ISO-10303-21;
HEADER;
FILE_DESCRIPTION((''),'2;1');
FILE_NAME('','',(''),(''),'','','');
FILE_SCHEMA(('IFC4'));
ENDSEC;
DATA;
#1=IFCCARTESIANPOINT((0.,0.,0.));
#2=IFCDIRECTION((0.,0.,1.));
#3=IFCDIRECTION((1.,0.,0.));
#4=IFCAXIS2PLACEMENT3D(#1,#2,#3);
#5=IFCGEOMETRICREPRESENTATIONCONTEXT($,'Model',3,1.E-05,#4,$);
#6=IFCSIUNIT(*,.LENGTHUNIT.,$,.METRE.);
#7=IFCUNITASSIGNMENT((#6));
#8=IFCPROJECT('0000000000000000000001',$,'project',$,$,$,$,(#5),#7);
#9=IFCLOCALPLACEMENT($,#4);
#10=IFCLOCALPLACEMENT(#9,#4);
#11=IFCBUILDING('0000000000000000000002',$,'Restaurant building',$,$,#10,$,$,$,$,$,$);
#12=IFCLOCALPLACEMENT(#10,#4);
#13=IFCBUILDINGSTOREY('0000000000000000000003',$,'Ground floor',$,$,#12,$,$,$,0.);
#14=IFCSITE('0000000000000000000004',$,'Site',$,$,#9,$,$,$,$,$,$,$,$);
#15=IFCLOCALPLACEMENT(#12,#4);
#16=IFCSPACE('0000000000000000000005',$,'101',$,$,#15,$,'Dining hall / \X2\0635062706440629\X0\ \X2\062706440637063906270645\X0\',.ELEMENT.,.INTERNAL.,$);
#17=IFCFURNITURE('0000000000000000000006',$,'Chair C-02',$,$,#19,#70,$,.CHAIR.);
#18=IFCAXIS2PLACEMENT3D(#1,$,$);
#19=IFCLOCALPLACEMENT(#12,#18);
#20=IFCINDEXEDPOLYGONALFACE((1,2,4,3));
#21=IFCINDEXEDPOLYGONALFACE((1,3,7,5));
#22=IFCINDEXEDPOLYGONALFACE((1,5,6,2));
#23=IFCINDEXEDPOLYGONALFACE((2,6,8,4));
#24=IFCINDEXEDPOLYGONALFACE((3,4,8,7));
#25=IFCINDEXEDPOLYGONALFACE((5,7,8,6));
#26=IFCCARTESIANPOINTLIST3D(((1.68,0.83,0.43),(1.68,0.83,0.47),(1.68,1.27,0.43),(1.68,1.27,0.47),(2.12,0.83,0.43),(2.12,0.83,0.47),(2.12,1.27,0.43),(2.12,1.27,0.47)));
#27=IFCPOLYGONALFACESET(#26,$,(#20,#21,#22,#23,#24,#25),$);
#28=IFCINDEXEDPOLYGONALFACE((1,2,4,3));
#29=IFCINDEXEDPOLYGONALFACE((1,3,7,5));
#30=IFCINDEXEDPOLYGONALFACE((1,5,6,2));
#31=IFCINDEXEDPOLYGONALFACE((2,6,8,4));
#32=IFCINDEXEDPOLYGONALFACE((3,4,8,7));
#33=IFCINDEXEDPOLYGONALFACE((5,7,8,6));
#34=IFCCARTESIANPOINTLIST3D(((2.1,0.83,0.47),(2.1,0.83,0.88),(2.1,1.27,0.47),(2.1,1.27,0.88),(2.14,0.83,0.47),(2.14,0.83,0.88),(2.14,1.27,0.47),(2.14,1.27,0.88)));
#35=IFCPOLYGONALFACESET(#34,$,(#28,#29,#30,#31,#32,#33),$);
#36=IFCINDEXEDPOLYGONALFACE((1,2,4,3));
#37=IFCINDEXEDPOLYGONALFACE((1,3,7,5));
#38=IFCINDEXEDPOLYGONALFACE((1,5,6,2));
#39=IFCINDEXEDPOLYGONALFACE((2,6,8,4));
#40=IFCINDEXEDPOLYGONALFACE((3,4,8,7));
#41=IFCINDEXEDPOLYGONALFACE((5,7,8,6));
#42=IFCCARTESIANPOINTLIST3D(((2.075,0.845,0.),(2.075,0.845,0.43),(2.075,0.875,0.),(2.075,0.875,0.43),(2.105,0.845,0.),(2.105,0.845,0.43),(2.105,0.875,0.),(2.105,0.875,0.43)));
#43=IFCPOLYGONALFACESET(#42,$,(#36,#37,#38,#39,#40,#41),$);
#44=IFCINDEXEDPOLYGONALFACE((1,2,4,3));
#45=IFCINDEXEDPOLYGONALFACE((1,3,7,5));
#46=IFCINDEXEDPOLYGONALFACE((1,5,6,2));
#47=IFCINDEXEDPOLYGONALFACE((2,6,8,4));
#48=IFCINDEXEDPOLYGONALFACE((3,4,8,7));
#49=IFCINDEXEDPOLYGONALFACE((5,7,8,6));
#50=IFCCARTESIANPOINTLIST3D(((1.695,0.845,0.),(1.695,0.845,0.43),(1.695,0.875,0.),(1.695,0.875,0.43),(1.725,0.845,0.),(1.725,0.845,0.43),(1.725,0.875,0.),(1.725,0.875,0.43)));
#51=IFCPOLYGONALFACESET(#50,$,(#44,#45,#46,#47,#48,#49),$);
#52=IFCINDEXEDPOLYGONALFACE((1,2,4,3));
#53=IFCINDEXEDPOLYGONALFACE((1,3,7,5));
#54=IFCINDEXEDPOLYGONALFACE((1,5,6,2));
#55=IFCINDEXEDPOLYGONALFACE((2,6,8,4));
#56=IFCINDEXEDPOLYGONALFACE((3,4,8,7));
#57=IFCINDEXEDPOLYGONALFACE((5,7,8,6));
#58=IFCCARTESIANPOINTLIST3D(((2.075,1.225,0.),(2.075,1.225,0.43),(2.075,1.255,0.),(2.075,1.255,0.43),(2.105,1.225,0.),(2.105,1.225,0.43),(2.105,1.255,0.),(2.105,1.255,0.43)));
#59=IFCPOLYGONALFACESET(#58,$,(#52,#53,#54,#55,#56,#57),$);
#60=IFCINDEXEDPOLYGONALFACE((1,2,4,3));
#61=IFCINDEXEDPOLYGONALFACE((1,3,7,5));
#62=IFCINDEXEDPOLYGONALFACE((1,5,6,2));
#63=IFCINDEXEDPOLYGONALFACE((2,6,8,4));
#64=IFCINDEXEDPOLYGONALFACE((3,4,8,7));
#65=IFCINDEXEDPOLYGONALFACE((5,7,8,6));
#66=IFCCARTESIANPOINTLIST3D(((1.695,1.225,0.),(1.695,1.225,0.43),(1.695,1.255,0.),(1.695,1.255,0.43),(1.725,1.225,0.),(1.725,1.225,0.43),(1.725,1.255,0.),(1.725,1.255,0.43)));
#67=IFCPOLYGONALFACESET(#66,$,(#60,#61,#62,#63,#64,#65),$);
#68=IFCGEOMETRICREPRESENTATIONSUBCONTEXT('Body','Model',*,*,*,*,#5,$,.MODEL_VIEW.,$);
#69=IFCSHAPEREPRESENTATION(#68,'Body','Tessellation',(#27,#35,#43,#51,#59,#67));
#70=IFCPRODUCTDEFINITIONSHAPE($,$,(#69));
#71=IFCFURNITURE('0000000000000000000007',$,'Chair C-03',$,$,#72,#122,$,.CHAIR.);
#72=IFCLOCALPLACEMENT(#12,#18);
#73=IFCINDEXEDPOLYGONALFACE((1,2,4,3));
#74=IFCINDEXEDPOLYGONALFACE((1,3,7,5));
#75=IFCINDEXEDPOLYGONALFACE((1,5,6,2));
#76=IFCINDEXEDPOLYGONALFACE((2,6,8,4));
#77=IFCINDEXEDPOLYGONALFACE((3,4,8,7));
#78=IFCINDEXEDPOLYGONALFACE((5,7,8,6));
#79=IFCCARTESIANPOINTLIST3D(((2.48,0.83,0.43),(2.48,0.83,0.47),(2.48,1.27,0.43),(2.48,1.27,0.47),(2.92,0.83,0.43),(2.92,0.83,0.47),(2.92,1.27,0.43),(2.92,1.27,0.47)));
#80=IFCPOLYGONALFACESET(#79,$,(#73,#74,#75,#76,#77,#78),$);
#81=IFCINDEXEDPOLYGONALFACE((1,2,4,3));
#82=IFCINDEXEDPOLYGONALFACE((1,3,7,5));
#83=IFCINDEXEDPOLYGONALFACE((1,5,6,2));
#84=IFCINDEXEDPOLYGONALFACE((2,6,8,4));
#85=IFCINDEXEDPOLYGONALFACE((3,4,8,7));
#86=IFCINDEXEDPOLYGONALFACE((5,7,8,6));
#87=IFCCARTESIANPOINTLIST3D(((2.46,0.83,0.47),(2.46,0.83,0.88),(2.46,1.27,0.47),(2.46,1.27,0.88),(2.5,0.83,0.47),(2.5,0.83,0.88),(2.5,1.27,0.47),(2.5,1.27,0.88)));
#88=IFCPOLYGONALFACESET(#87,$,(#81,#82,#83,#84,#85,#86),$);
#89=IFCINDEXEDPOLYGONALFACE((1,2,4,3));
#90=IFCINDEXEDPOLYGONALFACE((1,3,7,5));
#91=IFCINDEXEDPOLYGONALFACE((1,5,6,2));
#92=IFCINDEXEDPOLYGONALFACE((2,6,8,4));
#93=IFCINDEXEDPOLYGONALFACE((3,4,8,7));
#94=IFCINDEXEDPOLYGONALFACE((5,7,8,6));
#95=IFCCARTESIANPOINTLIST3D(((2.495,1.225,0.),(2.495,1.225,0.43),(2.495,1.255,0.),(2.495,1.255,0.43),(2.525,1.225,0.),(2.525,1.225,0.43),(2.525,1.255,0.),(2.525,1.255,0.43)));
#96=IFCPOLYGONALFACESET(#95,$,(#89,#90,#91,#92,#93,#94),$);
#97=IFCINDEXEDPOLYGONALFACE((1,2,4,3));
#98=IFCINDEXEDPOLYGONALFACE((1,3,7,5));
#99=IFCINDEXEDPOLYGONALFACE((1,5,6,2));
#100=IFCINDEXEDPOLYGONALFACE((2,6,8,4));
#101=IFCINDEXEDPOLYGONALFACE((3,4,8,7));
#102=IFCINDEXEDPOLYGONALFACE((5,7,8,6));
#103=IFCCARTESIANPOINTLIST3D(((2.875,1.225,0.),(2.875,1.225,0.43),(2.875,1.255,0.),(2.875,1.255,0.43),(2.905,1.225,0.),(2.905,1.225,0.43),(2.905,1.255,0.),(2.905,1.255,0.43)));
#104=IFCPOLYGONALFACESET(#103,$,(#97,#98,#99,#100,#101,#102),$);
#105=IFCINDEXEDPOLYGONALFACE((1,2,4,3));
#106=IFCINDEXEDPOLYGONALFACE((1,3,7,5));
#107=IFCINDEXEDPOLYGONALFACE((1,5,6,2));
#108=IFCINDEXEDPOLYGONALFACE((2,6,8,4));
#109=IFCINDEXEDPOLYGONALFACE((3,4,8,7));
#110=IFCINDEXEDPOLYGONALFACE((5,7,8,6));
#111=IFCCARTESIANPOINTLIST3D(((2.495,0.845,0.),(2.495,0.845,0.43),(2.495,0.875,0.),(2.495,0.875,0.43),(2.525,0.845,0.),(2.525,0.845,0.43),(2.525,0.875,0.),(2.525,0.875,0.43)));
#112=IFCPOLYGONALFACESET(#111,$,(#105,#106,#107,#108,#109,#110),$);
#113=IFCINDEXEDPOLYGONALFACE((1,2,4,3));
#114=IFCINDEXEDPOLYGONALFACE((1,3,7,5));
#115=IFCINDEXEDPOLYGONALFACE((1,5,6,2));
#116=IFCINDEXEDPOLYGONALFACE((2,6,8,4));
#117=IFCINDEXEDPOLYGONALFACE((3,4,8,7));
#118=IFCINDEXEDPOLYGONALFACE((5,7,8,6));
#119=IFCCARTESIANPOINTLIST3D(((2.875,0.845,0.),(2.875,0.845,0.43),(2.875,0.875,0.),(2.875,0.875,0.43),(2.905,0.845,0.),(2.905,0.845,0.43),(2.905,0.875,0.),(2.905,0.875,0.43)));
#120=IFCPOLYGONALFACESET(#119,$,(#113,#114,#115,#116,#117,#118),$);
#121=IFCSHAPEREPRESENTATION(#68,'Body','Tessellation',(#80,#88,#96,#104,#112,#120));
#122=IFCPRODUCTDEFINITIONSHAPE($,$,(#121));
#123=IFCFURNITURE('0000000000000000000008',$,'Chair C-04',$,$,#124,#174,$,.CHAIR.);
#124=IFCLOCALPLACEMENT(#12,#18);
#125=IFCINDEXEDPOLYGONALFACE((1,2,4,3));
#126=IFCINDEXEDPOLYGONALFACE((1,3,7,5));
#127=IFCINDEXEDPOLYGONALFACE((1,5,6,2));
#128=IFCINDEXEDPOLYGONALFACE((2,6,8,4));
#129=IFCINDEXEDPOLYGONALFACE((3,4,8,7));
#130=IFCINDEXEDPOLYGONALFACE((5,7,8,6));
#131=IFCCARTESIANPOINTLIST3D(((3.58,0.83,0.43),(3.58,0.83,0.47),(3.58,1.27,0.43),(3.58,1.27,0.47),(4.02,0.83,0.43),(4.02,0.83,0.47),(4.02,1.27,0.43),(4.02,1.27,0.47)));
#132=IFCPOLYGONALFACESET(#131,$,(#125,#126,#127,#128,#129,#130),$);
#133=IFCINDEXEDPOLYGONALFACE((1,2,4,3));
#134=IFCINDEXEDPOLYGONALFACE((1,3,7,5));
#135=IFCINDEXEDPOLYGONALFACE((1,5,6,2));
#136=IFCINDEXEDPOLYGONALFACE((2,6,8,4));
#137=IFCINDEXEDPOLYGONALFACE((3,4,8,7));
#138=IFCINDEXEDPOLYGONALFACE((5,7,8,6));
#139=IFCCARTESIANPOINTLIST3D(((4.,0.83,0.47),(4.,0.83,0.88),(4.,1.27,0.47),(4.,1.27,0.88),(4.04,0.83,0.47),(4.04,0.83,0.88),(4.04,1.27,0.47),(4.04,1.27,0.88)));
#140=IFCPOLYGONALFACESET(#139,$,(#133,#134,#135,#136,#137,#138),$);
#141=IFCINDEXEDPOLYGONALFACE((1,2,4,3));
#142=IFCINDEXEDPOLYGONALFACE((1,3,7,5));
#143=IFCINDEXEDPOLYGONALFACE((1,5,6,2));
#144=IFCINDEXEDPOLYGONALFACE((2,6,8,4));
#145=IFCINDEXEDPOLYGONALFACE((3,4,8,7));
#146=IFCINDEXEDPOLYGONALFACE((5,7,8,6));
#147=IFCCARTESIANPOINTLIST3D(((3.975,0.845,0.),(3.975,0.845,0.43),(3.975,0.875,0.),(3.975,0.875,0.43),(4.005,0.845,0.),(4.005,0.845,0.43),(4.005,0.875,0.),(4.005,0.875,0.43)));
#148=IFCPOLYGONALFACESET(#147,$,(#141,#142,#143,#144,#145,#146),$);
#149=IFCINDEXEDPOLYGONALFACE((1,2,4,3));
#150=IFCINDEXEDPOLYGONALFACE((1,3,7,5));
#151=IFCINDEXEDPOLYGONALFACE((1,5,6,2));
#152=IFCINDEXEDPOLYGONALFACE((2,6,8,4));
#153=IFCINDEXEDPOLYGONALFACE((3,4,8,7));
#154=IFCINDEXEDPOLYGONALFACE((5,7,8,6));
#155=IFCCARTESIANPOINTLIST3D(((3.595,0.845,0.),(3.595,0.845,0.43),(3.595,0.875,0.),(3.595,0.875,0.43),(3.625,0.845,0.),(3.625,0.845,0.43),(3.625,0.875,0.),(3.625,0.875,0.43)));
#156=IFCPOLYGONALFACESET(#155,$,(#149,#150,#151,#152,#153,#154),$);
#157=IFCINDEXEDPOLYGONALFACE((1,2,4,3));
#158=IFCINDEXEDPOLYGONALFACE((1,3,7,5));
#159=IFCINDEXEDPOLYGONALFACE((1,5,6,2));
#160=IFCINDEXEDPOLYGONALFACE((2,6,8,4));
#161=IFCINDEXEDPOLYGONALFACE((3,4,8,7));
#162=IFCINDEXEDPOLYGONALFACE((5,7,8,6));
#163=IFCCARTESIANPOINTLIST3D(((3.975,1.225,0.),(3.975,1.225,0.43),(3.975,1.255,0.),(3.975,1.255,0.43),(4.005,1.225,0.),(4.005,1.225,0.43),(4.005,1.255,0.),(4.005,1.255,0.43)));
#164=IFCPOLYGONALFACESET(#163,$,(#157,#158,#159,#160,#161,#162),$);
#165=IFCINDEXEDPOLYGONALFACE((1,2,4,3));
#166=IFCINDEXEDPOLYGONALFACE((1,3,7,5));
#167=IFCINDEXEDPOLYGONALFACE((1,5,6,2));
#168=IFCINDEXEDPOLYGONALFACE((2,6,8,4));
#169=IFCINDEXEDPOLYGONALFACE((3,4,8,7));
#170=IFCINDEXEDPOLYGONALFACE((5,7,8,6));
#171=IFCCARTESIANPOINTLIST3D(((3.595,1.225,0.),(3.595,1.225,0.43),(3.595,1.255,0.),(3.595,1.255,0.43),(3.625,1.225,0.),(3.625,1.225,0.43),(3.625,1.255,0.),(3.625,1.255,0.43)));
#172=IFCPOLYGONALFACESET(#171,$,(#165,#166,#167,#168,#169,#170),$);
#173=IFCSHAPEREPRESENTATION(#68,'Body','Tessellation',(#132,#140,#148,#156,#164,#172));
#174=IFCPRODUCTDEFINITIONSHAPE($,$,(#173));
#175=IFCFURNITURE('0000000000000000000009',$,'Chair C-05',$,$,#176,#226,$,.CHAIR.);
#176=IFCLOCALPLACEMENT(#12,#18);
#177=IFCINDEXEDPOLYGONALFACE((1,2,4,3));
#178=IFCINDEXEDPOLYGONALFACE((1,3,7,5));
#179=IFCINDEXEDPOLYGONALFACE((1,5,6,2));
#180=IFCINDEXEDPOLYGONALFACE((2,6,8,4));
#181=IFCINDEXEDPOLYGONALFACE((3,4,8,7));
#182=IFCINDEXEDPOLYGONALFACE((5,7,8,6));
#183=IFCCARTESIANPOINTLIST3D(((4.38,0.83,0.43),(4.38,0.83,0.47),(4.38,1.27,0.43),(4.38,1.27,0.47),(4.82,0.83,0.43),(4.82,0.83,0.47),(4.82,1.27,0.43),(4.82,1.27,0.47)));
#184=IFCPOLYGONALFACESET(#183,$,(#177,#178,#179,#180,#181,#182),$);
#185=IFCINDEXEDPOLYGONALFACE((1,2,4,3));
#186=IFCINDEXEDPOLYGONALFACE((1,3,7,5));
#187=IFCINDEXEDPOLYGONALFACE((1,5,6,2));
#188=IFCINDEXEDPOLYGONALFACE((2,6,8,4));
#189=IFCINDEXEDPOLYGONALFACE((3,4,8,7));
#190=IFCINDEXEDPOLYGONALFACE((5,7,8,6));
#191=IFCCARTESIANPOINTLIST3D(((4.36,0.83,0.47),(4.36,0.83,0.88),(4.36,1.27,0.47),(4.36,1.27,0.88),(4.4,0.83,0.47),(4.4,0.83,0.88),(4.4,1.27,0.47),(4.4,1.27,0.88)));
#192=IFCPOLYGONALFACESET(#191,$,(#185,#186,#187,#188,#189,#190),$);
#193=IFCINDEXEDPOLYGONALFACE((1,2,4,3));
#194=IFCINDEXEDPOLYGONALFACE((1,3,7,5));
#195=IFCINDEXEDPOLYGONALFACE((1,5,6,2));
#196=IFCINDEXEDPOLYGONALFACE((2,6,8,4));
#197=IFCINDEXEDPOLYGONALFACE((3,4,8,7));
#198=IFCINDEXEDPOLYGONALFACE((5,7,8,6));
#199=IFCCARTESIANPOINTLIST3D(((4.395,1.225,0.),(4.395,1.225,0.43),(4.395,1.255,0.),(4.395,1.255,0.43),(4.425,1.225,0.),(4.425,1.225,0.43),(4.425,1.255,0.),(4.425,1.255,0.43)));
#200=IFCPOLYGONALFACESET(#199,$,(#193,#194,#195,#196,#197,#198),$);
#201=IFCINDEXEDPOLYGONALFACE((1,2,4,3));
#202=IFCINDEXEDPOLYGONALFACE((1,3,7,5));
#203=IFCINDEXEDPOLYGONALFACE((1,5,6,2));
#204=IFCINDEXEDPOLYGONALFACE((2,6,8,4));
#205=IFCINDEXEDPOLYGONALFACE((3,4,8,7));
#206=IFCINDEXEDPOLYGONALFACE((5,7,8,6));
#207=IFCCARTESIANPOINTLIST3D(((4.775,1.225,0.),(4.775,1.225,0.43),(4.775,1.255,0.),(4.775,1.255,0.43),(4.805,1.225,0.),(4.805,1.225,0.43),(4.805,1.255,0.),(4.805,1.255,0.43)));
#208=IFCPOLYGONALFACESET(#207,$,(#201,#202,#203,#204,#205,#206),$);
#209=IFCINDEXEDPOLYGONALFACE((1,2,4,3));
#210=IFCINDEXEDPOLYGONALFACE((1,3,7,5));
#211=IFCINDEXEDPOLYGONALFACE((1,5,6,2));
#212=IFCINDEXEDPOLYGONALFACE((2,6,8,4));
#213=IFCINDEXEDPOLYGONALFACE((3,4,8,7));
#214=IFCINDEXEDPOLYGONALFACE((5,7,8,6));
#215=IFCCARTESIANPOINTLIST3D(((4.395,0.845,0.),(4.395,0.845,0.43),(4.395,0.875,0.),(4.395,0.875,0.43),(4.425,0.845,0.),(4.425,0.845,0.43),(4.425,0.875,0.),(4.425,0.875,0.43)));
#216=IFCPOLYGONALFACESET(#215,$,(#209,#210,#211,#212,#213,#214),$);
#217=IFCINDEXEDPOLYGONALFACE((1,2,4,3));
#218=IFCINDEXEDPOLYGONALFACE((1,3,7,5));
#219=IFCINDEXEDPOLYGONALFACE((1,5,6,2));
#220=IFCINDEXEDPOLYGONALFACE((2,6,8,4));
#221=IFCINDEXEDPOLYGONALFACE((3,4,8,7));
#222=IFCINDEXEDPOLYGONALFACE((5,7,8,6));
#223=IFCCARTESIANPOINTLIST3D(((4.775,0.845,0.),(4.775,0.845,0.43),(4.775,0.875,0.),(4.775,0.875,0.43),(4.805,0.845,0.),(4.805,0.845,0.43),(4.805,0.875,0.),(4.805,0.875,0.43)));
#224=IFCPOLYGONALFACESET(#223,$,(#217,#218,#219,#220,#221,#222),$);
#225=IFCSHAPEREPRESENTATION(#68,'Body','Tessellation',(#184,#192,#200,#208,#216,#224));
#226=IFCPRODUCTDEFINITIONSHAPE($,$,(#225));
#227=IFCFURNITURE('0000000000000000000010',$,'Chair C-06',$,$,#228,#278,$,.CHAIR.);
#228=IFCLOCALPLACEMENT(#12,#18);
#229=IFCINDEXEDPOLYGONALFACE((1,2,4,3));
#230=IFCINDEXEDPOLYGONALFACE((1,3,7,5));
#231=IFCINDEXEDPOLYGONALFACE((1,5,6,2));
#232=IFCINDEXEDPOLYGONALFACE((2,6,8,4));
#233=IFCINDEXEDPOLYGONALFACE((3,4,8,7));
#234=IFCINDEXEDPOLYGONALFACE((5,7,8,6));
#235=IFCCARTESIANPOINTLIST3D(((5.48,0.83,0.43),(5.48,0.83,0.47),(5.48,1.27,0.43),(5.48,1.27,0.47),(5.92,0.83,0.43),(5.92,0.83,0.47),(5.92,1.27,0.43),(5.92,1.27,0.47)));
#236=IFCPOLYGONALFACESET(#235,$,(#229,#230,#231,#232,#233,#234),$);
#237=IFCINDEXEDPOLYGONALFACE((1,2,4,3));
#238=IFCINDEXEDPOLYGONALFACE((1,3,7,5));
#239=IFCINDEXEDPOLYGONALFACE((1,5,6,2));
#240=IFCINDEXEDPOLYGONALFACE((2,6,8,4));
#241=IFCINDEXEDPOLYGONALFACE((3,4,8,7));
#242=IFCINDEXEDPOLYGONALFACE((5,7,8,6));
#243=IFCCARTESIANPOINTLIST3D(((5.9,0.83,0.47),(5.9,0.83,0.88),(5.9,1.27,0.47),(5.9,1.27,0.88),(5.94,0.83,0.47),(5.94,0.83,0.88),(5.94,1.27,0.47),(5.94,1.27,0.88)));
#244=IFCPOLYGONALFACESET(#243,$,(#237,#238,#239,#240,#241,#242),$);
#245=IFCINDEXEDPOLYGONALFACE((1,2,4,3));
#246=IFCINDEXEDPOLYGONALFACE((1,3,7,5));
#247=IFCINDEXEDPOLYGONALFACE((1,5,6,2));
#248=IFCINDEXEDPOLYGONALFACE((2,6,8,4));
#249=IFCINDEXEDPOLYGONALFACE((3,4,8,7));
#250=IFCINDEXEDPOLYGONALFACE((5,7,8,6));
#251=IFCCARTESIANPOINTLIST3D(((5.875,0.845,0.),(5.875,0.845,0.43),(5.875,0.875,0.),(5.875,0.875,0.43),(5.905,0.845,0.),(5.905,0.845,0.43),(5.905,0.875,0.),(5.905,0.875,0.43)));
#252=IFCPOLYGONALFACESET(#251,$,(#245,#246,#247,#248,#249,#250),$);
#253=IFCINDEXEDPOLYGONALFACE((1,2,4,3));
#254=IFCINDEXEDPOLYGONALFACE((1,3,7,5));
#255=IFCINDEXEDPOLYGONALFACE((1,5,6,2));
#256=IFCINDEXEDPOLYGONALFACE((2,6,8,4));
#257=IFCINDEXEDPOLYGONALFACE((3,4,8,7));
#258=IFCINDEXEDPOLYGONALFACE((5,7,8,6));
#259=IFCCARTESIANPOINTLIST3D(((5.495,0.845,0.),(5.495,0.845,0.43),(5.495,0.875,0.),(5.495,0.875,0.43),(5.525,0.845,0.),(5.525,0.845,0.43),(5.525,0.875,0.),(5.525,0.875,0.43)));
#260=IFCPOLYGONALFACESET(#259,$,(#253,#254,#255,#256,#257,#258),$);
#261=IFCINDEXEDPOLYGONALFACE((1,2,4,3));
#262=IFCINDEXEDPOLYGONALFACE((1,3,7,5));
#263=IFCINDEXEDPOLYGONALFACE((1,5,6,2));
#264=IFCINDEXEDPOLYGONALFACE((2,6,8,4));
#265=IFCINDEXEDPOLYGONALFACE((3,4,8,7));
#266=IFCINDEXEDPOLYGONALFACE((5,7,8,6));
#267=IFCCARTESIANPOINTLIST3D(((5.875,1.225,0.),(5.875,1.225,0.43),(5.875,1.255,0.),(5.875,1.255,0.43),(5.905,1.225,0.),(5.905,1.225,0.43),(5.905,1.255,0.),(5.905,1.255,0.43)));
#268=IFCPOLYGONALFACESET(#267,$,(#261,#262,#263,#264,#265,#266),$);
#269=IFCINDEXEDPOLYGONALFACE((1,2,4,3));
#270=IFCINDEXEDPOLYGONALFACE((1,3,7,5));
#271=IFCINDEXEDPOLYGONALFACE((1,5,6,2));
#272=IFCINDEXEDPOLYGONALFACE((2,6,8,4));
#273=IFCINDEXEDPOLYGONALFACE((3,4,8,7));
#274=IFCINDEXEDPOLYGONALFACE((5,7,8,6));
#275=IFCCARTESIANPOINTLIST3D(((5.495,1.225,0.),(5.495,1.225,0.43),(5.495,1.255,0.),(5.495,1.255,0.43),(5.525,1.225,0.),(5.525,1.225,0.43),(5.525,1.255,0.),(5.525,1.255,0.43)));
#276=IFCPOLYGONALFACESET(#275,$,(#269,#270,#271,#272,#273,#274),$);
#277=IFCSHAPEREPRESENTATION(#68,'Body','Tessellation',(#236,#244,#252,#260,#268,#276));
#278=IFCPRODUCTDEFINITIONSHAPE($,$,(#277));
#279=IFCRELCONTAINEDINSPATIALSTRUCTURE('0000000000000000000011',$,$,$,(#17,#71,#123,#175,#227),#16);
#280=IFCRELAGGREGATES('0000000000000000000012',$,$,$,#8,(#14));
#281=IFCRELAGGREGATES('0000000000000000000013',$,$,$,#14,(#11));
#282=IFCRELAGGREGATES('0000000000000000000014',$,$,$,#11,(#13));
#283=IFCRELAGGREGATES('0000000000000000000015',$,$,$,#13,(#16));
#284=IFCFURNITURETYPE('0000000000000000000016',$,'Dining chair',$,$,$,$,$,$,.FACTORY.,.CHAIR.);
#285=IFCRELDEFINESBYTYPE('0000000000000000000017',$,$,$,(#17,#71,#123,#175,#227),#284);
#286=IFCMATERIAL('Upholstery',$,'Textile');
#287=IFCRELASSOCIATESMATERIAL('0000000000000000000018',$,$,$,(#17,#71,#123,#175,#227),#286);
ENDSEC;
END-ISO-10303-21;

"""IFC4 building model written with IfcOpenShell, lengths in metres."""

from ifc_helpers import new_model, si_unit, frame, origin, origin_with_axes, origin_2d, place, context, subcontext, project, spatial, rectangle, extrude, source, transform, mapped, material, type_object, type_shapes, element, save


model = new_model("IFC4")

# Units and contexts
model_context = context("Model", 3, precision=1e-05, world=origin_with_axes())
body_context = subcontext(model_context, "Body", "Model", "MODEL_VIEW")
ifc_project = project(units=[si_unit("LENGTHUNIT", "METRE")], contexts=[model_context])

# Site, building, storey, space
site_placement = place(None, origin_with_axes())
site = spatial("IfcSite", under=ifc_project, at=site_placement, Name="Site")
building_placement = place(site_placement, origin_with_axes())
building = spatial("IfcBuilding", under=site, at=building_placement, Name="Restaurant building")
storey_placement = place(building_placement, origin_with_axes())
storey = spatial("IfcBuildingStorey", under=building, at=storey_placement, Name="Ground floor", Elevation=0.0)
space_placement = place(storey_placement, origin_with_axes())
space = spatial("IfcSpace", under=storey, at=space_placement, Name="101", LongName="Dining hall / صالة الطعام", CompositionType="ELEMENT", PredefinedType="INTERNAL")

# Furniture
ifc_material_1 = material(Name="Upholstery", Category="Textile")
furniture_type_1 = type_object("IfcFurnitureType", Name="Dining chair", AssemblyPlace="FACTORY", PredefinedType="CHAIR")
shared_shape_1 = source(origin(), body_context, "Body", "SweptSolid", [
    extrude(rectangle(XDim=0.44, YDim=0.44, at=origin_2d()), frame((0.0, 0.0, 0.43)), (0.0, 0.0, 1.0), 0.04),
    extrude(rectangle(XDim=0.44, YDim=0.04, at=origin_2d()), frame((0.0, -0.22, 0.47)), (0.0, 0.0, 1.0), 0.41),
    extrude(rectangle(XDim=0.03, YDim=0.03, at=origin_2d()), frame((-0.19, -0.19, 0.0)), (0.0, 0.0, 1.0), 0.43),
    extrude(rectangle(XDim=0.03, YDim=0.03, at=origin_2d()), frame((-0.19, 0.19, 0.0)), (0.0, 0.0, 1.0), 0.43),
    extrude(rectangle(XDim=0.03, YDim=0.03, at=origin_2d()), frame((0.19, -0.19, 0.0)), (0.0, 0.0, 1.0), 0.43),
    extrude(rectangle(XDim=0.03, YDim=0.03, at=origin_2d()), frame((0.19, 0.19, 0.0)), (0.0, 0.0, 1.0), 0.43),
])
type_shapes(furniture_type_1, [shared_shape_1])
for number, where, z_axis, x_axis, name in (
    (1, (1.9, 1.05, 0.0), (0.0, 0.0, 1.0), (0.0, 1.0, 0.0), "Chair C-02"),
    (2, (2.7, 1.05, 0.0), (0.0, 0.0, 1.0), (0.0, -1.0, 0.0), "Chair C-03"),
    (3, (3.8, 1.05, 0.0), (0.0, 0.0, 1.0), (0.0, 1.0, 0.0), "Chair C-04"),
    (4, (4.6, 1.05, 0.0), (0.0, 0.0, 1.0), (0.0, -1.0, 0.0), "Chair C-05"),
    (5, (5.7, 1.05, 0.0), (0.0, 0.0, 1.0), (0.0, 1.0, 0.0), "Chair C-06"),
):
    element("IfcFurniture", number, at=place(storey_placement, frame(where, z_axis=z_axis, x_axis=x_axis)), inside=space, type_object=furniture_type_1, material=ifc_material_1, Name=name, PredefinedType="CHAIR", context=body_context, shape_type="MappedRepresentation", body=[
        mapped(shared_shape_1, transform((0.0, 0.0, 0.0))),
    ])

save(model, "model.ifc")
